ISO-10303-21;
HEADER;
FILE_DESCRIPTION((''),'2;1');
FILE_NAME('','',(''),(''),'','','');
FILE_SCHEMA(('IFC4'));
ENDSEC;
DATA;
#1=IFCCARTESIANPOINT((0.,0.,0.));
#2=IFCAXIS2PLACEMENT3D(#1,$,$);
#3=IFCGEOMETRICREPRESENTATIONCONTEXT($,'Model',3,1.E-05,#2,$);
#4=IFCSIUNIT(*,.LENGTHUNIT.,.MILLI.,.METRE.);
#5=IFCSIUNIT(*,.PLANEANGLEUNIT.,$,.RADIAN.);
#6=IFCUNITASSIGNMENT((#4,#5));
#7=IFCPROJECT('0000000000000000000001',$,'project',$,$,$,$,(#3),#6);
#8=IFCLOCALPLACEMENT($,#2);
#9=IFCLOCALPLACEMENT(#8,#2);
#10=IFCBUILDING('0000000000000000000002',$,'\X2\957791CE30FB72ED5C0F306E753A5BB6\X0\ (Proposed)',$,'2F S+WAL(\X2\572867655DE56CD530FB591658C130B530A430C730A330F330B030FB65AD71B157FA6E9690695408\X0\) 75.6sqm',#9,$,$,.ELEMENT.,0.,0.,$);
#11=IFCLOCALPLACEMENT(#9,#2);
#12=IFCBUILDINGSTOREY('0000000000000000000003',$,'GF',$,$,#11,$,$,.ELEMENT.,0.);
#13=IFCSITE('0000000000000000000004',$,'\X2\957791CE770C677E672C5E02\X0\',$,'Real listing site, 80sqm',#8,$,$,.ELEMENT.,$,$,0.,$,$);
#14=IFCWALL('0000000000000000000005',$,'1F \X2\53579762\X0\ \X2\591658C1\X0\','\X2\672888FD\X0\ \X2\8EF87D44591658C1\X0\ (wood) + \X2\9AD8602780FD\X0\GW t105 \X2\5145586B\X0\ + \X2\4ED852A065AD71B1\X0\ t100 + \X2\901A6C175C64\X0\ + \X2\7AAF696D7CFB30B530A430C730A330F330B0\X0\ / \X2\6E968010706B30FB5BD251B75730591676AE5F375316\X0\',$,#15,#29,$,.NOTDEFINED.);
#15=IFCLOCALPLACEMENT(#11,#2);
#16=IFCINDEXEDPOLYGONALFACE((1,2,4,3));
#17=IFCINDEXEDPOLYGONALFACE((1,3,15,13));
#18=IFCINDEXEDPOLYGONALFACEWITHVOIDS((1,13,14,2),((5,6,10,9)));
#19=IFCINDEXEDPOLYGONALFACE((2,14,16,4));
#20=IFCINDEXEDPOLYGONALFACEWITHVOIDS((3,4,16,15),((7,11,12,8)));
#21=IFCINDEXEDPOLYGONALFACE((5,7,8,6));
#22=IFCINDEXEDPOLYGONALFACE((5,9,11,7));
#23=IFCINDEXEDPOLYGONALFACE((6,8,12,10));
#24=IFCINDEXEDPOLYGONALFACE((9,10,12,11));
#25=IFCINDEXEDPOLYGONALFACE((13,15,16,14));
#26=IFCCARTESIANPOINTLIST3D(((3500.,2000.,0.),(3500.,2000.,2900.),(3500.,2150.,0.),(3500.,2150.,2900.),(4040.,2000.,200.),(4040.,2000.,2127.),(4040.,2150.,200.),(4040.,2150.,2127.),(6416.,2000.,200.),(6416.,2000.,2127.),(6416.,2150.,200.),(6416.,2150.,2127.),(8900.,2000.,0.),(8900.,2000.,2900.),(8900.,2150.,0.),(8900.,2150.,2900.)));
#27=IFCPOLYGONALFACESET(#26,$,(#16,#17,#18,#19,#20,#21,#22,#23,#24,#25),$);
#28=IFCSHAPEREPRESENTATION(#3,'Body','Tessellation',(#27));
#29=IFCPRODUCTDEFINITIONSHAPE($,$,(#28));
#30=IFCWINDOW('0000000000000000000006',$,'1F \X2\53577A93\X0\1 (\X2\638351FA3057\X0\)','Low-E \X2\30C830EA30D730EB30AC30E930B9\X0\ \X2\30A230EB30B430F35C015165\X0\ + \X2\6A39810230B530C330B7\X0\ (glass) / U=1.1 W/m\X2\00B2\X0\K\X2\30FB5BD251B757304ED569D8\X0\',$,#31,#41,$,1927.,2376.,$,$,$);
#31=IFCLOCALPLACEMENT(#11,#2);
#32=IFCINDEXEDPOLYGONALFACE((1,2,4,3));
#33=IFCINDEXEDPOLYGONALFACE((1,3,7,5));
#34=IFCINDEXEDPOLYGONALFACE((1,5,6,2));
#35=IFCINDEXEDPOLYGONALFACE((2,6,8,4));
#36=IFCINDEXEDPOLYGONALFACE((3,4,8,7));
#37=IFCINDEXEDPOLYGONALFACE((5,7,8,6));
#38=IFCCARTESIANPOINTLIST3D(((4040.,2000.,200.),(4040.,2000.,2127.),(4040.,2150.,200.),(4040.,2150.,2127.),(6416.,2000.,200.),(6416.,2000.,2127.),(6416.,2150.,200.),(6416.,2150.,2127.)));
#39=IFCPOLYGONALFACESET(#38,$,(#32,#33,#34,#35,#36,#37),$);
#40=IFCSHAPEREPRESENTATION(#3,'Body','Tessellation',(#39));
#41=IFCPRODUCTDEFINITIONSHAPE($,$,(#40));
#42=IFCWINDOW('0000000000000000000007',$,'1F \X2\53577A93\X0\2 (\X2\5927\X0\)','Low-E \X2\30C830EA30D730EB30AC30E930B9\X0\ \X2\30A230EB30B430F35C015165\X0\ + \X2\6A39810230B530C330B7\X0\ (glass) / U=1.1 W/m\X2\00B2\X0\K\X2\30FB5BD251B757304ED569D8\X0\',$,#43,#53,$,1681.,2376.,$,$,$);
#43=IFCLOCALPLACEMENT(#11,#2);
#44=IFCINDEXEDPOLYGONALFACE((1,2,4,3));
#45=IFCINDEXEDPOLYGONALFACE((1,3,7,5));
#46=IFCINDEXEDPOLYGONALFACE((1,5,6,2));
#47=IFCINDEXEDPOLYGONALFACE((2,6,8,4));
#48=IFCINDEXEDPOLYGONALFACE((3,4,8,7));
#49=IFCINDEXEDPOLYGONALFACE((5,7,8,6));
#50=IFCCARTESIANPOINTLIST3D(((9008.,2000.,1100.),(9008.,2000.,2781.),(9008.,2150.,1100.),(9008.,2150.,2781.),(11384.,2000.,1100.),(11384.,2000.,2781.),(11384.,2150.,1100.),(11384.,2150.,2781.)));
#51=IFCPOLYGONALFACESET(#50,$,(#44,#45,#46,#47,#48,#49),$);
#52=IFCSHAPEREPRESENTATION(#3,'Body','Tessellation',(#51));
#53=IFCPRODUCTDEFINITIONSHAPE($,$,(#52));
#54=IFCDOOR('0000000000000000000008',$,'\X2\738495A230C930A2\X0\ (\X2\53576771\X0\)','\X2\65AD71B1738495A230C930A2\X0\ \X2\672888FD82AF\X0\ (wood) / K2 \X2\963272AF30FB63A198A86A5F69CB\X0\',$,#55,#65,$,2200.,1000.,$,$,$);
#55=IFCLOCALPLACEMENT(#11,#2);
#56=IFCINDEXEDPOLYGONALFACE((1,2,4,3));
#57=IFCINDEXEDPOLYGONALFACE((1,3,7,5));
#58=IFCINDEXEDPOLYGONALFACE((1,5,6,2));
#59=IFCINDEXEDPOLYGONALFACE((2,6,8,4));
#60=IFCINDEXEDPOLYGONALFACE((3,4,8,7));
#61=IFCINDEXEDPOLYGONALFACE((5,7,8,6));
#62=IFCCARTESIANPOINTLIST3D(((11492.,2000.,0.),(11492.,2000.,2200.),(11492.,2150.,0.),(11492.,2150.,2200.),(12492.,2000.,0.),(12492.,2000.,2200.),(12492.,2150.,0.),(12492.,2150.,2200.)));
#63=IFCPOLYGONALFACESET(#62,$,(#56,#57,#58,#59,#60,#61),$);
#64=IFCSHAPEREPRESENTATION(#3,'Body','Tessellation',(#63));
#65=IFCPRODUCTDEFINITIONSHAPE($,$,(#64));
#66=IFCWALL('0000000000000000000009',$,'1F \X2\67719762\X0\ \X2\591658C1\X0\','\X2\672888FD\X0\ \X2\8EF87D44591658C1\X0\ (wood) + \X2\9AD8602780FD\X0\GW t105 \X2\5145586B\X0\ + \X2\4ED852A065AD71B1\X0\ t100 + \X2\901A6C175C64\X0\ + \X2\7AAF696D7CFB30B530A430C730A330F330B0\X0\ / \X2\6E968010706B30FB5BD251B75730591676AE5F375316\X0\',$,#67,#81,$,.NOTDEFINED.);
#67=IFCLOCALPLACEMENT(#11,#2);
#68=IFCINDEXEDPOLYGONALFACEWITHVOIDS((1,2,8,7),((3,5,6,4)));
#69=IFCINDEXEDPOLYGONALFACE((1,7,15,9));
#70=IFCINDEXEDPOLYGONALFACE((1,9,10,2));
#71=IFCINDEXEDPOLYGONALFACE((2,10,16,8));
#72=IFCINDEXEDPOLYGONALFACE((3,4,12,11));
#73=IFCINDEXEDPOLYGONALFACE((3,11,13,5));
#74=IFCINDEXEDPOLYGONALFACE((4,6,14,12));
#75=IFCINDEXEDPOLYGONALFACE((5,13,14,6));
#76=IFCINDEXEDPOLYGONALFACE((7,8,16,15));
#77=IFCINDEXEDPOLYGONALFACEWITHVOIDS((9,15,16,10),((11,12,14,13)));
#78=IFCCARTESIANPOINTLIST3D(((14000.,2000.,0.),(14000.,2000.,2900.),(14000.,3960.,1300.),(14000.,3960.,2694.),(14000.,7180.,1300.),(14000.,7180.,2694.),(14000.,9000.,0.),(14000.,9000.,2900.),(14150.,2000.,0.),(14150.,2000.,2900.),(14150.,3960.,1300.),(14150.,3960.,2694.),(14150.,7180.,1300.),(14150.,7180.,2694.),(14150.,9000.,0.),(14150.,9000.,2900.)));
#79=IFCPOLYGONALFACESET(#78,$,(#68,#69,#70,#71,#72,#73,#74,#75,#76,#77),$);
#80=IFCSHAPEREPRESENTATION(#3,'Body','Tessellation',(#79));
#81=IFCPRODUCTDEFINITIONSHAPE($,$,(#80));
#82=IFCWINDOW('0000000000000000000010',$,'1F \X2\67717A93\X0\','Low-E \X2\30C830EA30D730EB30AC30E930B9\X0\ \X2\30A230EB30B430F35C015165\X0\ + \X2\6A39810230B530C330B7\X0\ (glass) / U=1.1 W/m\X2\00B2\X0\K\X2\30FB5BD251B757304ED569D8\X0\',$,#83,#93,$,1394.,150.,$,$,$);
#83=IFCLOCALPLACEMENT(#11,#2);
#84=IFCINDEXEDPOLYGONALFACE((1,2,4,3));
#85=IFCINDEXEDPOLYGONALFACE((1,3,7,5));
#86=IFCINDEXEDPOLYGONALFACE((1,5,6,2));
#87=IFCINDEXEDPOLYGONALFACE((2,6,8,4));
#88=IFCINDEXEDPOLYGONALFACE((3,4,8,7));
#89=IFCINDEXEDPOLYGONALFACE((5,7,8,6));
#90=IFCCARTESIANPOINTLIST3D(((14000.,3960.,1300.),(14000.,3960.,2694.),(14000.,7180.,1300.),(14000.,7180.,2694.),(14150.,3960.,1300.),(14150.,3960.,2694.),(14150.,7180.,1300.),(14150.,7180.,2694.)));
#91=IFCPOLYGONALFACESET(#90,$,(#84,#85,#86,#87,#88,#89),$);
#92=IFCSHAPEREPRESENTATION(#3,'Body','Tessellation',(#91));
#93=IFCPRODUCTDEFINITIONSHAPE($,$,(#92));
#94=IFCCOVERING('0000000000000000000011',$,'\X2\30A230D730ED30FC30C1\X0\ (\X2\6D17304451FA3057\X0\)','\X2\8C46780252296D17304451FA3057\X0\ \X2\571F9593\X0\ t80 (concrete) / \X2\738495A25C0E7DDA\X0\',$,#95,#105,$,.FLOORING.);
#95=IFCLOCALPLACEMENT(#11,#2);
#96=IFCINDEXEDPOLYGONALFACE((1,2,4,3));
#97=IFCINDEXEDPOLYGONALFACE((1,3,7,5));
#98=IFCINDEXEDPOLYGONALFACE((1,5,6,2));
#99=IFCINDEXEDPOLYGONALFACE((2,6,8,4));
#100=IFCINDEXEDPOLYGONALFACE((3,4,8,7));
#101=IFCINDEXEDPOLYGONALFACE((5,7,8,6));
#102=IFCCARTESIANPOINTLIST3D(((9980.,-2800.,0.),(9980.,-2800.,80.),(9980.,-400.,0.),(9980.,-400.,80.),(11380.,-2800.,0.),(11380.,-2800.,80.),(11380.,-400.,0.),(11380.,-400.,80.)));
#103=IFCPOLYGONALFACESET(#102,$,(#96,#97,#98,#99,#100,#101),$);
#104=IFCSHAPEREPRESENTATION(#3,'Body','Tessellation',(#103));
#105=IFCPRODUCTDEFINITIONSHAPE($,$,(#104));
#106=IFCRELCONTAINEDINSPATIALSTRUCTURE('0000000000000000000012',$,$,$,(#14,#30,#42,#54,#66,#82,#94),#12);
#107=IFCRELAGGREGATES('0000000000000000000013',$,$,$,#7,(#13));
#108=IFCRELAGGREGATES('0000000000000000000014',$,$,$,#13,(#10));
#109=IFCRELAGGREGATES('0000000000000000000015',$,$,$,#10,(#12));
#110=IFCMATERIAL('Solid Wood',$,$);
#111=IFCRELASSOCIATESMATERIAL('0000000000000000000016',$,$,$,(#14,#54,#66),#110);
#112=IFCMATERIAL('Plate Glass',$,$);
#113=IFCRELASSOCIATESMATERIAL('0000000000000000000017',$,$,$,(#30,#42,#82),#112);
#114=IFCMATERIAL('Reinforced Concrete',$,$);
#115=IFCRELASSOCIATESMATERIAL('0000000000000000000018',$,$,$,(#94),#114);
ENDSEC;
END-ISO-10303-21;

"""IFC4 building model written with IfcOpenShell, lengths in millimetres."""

from ifc_helpers import new_model, si_unit, frame, frame_2d, origin, place, context, project, spatial, rectangle, extrude, material, element, fill, save


model = new_model("IFC4")

# Units and contexts
model_context = context("Model", 3, precision=1e-05, world=origin())
ifc_project = project(units=[si_unit("LENGTHUNIT", "METRE", prefix="MILLI"), si_unit("PLANEANGLEUNIT", "RADIAN")], contexts=[model_context])

# Site, building, storey
site_placement = place(None, origin())
site = spatial("IfcSite", under=ifc_project, at=site_placement, Name="長野県松本市", ObjectType="Real listing site, 80sqm", CompositionType="ELEMENT", RefElevation=0.0)
building_placement = place(site_placement, origin())
building = spatial("IfcBuilding", under=site, at=building_placement, Name="長野・狭小の町家 (Proposed)", ObjectType="2F S+WAL(在来工法・外壁サイディング・断熱基準適合) 75.6sqm", CompositionType="ELEMENT", ElevationOfRefHeight=0.0, ElevationOfTerrain=0.0)
storey_placement = place(building_placement, origin())
storey = spatial("IfcBuildingStorey", under=building, at=storey_placement, Name="GF", CompositionType="ELEMENT", Elevation=0.0)

# Shared definitions
ifc_material_1 = material(Name="Solid Wood")

# Shared definitions
ifc_material_2 = material(Name="Reinforced Concrete")

# Wall, openings, windows, door
wall_1_placement = place(storey_placement, frame((1750.0, 1000.0, 0.0)))
wall_1 = element("IfcWall", 1, at=wall_1_placement, inside=storey, material=ifc_material_1, Name="1F 南面 外壁", Description="木製 軸組外壁 (wood) + 高性能GW t105 充填 + 付加断熱 t100 + 通気層 + 窯業系サイディング / 準耐火・寒冷地外皮強化", PredefinedType="NOTDEFINED", context=model_context, shape_type="SweptSolid", body=[
    extrude(rectangle(XDim=5400.0, YDim=150.0, at=frame_2d((2700.0, 75.0))), frame((1750.0, 1000.0, 0.0)), (0.0, 0.0, 1.0), 2900.0),
])
opening_1_placement = place(storey_placement, frame((2020.0, 1000.0, 100.0)))
opening_1 = element("IfcOpeningElement", 2, at=opening_1_placement, cuts=wall_1, PredefinedType="NOTDEFINED", context=model_context, shape_type="SweptSolid", body=[
    extrude(rectangle(XDim=2376.0, YDim=150.0, at=frame_2d((1188.0, 75.0))), frame((2020.0, 1000.0, 100.0)), (0.0, 0.0, 1.0), 1927.0),
])
opening_2_placement = place(storey_placement, frame((4504.0, 1000.0, 550.0)))
opening_2 = element("IfcOpeningElement", 3, at=opening_2_placement, cuts=wall_1, PredefinedType="NOTDEFINED", context=model_context, shape_type="SweptSolid", body=[
    extrude(rectangle(XDim=2376.0, YDim=150.0, at=frame_2d((1188.0, 75.0))), frame((4504.0, 1000.0, 550.0)), (0.0, 0.0, 1.0), 1681.0),
])
opening_3_placement = place(storey_placement, frame((5746.0, 1000.0, 0.0)))
opening_3 = element("IfcOpeningElement", 4, at=opening_3_placement, cuts=wall_1, PredefinedType="NOTDEFINED", context=model_context, shape_type="SweptSolid", body=[
    extrude(rectangle(XDim=1000.0, YDim=150.0, at=frame_2d((500.0, 75.0))), frame((5746.0, 1000.0, 0.0)), (0.0, 0.0, 1.0), 2200.0),
])
ifc_material_3 = material(Name="Plate Glass")
window_1_placement = place(storey_placement, frame((2020.0, 1000.0, 100.0)))
window_1 = element("IfcWindow", 5, at=window_1_placement, inside=storey, material=ifc_material_3, Name="1F 南窓1 (掃出し)", Description="Low-E トリプルガラス アルゴン封入 + 樹脂サッシ (glass) / U=1.1 W/m²K・寒冷地仕様", OverallHeight=1927.0, OverallWidth=2376.0, context=model_context, shape_type="SweptSolid", body=[
    extrude(rectangle(XDim=2376.0, YDim=150.0, at=frame_2d((1188.0, 75.0))), frame((2020.0, 1000.0, 100.0)), (0.0, 0.0, 1.0), 1927.0),
])
fill(opening_1, window_1)
window_2_placement = place(storey_placement, frame((4504.0, 1000.0, 550.0)))
window_2 = element("IfcWindow", 6, at=window_2_placement, inside=storey, material=ifc_material_3, Name="1F 南窓2 (大)", Description="Low-E トリプルガラス アルゴン封入 + 樹脂サッシ (glass) / U=1.1 W/m²K・寒冷地仕様", OverallHeight=1681.0, OverallWidth=2376.0, context=model_context, shape_type="SweptSolid", body=[
    extrude(rectangle(XDim=2376.0, YDim=150.0, at=frame_2d((1188.0, 75.0))), frame((4504.0, 1000.0, 550.0)), (0.0, 0.0, 1.0), 1681.0),
])
fill(opening_2, window_2)
door_placement = place(storey_placement, frame((5746.0, 1000.0, 0.0)))
door = element("IfcDoor", 7, at=door_placement, inside=storey, material=ifc_material_1, Name="玄関ドア (南東)", Description="断熱玄関ドア 木製芯 (wood) / K2 防犯・採風機構", OverallHeight=2200.0, OverallWidth=1000.0, context=model_context, shape_type="SweptSolid", body=[
    extrude(rectangle(XDim=1000.0, YDim=150.0, at=frame_2d((500.0, 75.0))), frame((5746.0, 1000.0, 0.0)), (0.0, 0.0, 1.0), 2200.0),
])
fill(opening_3, door)

# Wall, opening, window
wall_2_placement = place(storey_placement, frame((7000.0, 1000.0, 0.0)))
wall_2 = element("IfcWall", 8, at=wall_2_placement, inside=storey, material=ifc_material_1, Name="1F 東面 外壁", Description="木製 軸組外壁 (wood) + 高性能GW t105 充填 + 付加断熱 t100 + 通気層 + 窯業系サイディング / 準耐火・寒冷地外皮強化", PredefinedType="NOTDEFINED", context=model_context, shape_type="SweptSolid", body=[
    extrude(rectangle(XDim=150.0, YDim=7000.0, at=frame_2d((75.0, 3500.0))), frame((7000.0, 1000.0, 0.0)), (0.0, 0.0, 1.0), 2900.0),
])
opening_4_placement = place(storey_placement, frame((7000.0, 1980.0, 650.0)))
opening_4 = element("IfcOpeningElement", 9, at=opening_4_placement, cuts=wall_2, PredefinedType="NOTDEFINED", context=model_context, shape_type="SweptSolid", body=[
    extrude(rectangle(XDim=150.0, YDim=3220.0, at=frame_2d((75.0, 1610.0))), frame((7000.0, 1980.0, 650.0)), (0.0, 0.0, 1.0), 1394.0),
])
window_3_placement = place(storey_placement, frame((7000.0, 1980.0, 650.0)))
window_3 = element("IfcWindow", 10, at=window_3_placement, inside=storey, material=ifc_material_3, Name="1F 東窓", Description="Low-E トリプルガラス アルゴン封入 + 樹脂サッシ (glass) / U=1.1 W/m²K・寒冷地仕様", OverallHeight=1394.0, OverallWidth=150.0, context=model_context, shape_type="SweptSolid", body=[
    extrude(rectangle(XDim=150.0, YDim=3220.0, at=frame_2d((75.0, 1610.0))), frame((7000.0, 1980.0, 650.0)), (0.0, 0.0, 1.0), 1394.0),
])
fill(opening_4, window_3)

# Covering
covering_1_placement = place(storey_placement, frame((4990.0, -1400.0, 0.0)))
element("IfcCovering", 11, at=covering_1_placement, inside=storey, material=ifc_material_2, Name="アプローチ (洗い出し)", Description="豆砂利洗い出し 土間 t80 (concrete) / 玄関導線", PredefinedType="FLOORING", context=model_context, shape_type="SweptSolid", body=[
    extrude(rectangle(XDim=1400.0, YDim=2400.0, at=frame_2d((700.0, 1200.0))), frame((4990.0, -1400.0, 0.0)), (0.0, 0.0, 1.0), 80.0),
])

save(model, "model.ifc")
